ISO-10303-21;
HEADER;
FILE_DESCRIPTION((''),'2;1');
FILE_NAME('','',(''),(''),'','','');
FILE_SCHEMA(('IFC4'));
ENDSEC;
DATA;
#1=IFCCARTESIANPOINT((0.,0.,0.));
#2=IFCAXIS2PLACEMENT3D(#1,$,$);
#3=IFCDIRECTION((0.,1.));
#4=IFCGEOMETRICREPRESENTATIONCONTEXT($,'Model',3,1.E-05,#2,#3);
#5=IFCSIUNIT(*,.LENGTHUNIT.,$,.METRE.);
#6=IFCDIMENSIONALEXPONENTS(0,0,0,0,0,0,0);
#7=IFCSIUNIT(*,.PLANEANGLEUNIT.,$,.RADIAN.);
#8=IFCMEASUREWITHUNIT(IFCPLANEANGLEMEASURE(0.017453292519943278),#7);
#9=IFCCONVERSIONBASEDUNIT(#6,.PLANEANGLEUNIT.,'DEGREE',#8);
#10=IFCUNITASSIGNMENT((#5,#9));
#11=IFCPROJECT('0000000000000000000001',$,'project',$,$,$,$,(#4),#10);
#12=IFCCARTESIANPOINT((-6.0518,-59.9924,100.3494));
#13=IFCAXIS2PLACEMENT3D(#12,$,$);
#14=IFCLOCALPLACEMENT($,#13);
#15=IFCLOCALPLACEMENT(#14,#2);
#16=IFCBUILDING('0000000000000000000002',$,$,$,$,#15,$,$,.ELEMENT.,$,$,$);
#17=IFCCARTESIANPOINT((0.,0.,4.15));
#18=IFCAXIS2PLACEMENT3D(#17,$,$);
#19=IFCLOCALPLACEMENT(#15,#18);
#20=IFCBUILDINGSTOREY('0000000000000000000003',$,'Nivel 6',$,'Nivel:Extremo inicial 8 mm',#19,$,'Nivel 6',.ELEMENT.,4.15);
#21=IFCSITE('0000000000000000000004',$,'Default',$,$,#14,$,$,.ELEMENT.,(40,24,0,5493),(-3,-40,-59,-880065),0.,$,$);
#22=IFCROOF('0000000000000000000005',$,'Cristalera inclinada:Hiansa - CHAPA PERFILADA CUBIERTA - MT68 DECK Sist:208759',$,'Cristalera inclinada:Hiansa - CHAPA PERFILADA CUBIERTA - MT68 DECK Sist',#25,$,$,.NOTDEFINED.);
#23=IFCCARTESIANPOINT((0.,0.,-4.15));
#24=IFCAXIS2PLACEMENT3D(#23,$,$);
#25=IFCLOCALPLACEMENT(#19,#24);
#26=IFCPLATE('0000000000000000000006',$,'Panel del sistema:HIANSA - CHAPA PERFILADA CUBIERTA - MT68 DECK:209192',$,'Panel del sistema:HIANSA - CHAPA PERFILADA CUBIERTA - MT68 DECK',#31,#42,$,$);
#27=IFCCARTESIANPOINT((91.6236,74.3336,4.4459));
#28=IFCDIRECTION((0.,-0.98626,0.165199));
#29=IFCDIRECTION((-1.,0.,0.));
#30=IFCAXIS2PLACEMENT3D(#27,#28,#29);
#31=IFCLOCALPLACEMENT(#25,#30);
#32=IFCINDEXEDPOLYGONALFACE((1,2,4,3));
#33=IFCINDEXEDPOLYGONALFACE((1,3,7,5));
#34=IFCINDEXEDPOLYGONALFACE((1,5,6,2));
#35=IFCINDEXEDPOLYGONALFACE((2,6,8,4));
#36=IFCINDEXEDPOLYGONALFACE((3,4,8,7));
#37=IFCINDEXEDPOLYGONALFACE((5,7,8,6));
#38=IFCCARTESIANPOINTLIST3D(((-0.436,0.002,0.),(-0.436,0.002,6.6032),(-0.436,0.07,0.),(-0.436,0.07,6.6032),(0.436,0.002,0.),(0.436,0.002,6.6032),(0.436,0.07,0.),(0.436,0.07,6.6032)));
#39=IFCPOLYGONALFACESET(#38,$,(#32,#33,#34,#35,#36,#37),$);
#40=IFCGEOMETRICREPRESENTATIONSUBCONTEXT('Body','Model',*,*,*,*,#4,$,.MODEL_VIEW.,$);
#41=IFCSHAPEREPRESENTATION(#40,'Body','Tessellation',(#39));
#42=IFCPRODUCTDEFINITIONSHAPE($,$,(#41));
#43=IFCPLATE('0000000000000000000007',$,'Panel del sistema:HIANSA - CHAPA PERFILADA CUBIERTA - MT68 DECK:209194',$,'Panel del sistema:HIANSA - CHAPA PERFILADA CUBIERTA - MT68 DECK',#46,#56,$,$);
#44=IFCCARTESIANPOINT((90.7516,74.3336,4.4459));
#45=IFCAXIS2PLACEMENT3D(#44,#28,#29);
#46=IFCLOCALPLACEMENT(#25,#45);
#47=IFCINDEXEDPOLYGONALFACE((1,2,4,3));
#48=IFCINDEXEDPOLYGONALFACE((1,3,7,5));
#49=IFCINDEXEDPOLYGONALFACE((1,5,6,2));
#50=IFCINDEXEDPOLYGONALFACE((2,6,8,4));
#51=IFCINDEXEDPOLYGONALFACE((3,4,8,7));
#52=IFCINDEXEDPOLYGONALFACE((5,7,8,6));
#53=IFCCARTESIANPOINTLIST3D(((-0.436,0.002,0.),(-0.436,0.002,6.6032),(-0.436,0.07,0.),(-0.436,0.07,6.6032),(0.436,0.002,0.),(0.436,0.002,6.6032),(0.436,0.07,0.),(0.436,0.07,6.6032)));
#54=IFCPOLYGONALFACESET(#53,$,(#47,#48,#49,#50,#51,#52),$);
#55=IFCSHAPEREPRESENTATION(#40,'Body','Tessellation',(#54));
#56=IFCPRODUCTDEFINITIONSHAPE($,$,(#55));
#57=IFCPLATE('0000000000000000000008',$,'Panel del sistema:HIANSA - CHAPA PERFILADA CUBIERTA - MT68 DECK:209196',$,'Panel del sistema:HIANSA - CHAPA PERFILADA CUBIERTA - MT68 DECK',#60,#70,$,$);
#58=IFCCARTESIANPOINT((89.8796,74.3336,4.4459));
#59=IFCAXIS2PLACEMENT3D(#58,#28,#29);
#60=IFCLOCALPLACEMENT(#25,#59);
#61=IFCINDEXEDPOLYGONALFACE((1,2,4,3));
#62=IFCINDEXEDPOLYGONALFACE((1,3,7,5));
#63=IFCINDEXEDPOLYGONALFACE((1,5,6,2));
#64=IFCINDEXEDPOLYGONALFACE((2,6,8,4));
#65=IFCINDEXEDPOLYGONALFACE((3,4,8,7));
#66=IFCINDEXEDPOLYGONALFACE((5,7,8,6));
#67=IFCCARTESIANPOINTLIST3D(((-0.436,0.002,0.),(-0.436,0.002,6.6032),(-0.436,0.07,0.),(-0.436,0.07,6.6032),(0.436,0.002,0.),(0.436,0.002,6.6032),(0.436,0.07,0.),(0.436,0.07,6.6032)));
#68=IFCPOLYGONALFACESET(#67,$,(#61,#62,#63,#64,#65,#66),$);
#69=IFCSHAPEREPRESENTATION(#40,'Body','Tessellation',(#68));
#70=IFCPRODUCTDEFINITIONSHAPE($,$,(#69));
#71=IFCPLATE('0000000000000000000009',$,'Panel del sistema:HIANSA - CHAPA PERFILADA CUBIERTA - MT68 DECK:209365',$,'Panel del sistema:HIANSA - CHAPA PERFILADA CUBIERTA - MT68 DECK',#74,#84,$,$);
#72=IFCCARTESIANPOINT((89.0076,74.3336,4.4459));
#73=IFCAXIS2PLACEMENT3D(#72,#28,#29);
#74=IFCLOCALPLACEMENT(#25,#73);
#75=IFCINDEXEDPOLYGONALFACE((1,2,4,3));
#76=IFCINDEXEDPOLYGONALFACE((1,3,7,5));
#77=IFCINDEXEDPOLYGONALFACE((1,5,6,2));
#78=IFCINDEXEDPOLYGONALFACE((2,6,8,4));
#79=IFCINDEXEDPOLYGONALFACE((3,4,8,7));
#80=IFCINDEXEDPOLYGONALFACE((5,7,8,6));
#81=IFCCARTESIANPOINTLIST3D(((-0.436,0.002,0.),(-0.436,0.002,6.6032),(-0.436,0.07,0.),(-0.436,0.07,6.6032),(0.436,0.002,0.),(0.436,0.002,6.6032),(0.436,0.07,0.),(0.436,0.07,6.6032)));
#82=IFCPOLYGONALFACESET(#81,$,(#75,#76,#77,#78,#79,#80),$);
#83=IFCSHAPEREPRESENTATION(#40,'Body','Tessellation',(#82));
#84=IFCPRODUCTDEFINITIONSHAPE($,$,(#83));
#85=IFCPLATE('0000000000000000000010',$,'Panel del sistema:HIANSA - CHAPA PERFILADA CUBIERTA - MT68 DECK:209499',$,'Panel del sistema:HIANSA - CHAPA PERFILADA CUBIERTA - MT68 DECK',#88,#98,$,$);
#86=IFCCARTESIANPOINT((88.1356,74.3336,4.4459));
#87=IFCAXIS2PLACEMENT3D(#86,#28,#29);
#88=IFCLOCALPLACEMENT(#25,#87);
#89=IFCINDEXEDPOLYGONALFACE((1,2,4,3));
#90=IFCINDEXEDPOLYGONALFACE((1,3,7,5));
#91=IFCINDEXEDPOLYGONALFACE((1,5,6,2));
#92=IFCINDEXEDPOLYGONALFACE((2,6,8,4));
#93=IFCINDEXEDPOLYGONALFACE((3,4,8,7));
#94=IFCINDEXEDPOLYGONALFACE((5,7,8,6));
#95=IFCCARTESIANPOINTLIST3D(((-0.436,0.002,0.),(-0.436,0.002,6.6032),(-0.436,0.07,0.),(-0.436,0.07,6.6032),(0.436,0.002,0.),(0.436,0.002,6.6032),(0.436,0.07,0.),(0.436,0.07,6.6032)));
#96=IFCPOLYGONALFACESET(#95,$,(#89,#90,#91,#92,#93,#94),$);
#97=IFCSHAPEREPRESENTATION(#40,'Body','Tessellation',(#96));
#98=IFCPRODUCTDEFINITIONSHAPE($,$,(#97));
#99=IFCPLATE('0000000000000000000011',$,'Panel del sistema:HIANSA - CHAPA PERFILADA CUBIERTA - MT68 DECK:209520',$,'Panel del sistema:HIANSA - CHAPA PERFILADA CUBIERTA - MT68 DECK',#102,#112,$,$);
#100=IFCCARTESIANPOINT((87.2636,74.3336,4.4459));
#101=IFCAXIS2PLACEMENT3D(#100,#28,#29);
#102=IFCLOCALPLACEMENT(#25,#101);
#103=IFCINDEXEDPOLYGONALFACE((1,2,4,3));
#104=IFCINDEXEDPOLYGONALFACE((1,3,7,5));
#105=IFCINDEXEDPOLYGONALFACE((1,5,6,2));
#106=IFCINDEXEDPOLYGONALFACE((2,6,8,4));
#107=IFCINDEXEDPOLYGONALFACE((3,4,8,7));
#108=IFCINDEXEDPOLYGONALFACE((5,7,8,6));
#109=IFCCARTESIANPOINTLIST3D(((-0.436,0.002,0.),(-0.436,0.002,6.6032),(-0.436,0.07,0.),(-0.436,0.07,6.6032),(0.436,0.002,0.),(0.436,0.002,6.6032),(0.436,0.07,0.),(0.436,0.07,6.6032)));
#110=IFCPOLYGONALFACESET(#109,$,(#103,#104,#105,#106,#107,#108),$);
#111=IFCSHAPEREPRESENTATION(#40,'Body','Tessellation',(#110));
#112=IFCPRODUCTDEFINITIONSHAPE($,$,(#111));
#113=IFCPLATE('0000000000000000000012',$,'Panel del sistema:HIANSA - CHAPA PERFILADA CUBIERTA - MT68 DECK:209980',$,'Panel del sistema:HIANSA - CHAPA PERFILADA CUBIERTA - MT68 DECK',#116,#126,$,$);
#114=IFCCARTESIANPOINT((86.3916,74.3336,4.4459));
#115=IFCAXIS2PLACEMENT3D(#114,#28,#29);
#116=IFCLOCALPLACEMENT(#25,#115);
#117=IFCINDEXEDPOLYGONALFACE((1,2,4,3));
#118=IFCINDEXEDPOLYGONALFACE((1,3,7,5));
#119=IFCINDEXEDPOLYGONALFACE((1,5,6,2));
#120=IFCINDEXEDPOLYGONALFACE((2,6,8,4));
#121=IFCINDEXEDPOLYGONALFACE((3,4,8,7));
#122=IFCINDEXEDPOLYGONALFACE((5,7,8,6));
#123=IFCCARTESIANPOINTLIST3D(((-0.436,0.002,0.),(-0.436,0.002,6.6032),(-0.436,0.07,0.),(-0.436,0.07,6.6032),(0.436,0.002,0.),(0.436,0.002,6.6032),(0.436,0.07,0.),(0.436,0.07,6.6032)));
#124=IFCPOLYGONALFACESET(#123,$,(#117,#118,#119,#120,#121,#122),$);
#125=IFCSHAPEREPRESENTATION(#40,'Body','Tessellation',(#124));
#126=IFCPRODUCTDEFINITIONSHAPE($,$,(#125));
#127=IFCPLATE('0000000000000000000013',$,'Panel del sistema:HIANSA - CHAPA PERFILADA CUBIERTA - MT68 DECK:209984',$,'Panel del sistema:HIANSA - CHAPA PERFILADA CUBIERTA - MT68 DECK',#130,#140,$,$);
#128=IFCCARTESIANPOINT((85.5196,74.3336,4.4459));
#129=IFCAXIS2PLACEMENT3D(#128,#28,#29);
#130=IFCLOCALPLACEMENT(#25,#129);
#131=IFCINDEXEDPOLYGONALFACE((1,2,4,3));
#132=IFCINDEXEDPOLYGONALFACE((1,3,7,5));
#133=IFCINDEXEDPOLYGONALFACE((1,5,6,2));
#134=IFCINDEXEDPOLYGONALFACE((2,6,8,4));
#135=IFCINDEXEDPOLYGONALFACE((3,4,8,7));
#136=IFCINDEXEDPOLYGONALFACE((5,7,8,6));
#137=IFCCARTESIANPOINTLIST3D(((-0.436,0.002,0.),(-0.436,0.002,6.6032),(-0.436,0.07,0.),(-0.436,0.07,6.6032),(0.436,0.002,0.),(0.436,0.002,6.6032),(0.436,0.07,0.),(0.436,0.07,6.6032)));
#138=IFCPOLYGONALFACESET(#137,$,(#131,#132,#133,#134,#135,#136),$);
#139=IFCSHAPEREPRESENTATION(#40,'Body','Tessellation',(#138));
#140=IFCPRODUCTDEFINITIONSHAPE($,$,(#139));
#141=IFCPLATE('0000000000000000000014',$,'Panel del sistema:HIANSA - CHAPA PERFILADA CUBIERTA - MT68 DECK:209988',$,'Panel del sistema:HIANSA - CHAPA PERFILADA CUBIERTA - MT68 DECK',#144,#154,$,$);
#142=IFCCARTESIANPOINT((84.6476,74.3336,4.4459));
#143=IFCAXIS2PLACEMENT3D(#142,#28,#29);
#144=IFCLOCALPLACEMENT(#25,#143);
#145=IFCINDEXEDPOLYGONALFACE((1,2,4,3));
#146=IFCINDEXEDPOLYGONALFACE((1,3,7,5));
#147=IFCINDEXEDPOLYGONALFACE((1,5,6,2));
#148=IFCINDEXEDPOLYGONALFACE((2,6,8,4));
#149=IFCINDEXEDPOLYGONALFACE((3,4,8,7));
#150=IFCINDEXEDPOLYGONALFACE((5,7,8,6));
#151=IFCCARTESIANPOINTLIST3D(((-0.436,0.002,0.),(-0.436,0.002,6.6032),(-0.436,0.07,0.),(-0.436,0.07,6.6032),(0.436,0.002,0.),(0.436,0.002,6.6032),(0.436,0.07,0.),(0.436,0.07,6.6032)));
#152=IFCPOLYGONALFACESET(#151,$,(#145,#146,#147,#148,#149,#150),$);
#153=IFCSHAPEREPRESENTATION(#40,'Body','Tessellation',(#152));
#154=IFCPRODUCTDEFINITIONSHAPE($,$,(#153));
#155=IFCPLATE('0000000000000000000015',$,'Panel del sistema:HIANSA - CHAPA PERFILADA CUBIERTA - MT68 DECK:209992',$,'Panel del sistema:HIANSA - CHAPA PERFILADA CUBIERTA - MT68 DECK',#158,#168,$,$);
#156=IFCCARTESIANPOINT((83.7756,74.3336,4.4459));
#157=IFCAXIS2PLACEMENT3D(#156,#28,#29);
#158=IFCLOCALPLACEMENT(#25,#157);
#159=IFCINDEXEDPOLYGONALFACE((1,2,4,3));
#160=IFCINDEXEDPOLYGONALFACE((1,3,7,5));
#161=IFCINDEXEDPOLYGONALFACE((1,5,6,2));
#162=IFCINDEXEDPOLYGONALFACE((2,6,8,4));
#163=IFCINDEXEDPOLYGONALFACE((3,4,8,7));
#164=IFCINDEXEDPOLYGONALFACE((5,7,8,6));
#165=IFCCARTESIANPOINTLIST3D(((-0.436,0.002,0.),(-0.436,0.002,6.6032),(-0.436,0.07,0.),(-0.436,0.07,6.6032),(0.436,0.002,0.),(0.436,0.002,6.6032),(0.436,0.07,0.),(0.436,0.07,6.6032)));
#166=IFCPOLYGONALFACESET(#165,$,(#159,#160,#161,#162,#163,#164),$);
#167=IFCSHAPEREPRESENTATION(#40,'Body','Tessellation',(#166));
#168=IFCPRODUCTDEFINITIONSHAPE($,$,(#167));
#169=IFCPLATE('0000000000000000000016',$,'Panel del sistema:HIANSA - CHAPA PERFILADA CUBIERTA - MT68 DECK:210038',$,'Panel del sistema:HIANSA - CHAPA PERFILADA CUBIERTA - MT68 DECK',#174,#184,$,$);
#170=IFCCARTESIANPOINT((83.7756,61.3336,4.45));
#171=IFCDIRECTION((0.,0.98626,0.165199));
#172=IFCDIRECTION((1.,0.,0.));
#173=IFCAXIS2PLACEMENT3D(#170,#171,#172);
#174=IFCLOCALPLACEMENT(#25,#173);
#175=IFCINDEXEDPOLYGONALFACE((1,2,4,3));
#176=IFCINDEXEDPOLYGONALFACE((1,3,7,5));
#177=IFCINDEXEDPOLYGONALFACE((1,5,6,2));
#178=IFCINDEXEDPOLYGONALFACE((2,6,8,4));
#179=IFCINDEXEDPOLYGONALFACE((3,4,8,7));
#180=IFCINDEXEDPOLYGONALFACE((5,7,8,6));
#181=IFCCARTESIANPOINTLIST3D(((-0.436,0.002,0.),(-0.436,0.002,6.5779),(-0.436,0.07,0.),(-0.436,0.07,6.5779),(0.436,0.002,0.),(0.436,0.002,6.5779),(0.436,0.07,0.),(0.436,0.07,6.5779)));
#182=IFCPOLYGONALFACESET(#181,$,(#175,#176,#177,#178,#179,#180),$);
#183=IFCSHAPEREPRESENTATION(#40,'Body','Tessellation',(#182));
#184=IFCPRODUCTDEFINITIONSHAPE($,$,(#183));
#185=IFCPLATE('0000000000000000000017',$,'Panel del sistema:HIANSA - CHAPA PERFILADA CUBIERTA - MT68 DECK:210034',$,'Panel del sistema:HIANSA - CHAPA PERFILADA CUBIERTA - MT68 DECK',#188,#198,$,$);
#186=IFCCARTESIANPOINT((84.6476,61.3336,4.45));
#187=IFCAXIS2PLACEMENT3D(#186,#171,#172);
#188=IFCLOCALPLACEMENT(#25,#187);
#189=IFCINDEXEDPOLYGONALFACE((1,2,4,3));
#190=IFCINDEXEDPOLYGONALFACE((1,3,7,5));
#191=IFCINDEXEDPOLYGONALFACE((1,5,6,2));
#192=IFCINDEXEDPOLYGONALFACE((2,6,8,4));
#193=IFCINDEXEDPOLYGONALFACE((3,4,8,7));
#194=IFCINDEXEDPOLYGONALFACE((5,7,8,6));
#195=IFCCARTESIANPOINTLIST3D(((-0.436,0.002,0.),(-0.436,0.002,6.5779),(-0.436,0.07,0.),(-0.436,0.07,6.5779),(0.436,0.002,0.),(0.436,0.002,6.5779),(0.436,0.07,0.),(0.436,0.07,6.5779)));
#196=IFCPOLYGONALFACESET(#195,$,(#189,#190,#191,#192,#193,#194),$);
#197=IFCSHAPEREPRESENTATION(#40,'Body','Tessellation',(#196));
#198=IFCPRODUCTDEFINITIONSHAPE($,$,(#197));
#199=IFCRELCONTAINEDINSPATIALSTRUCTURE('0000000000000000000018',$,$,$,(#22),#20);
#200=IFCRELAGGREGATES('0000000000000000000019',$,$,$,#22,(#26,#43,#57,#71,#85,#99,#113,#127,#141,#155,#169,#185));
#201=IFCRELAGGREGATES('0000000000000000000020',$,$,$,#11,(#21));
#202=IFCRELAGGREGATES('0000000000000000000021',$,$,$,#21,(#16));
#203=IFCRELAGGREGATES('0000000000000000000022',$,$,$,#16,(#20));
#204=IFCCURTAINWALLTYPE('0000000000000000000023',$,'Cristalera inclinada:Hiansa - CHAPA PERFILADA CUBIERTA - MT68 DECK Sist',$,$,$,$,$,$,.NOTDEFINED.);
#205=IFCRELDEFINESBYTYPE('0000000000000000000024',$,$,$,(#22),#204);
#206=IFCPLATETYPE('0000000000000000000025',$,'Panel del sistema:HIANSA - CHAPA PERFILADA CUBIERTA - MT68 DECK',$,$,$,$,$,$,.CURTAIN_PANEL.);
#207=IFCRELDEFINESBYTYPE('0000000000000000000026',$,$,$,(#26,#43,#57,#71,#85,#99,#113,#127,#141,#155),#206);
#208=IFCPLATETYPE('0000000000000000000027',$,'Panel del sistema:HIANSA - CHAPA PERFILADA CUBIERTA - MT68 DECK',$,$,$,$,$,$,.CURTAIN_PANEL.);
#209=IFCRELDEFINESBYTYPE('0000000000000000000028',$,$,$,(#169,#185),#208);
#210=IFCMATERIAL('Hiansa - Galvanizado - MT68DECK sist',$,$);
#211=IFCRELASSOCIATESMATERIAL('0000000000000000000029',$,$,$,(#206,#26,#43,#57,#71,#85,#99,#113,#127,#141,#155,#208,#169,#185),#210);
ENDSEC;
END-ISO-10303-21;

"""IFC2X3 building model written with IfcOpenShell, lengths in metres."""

from ifc_helpers import new_model, entity, si_unit, converted_unit, direction, frame, origin, origin_2d_with_axis, place, context, subcontext, project, spatial, rectangle, extrude, source, transform, mapped, material, type_object, type_shapes, element, aggregate, save


model = new_model("IFC2X3")

# Units and contexts
model_context = context("Model", 3, precision=1e-05, world=origin(), true_north=direction((0.0, 1.0)))
body_context = subcontext(model_context, "Body", "Model", "MODEL_VIEW")
ifc_project = project(units=[si_unit("LENGTHUNIT", "METRE"), converted_unit("PLANEANGLEUNIT", "DEGREE", entity("IfcPlaneAngleMeasure", 0.017453292519943278), si_unit("PLANEANGLEUNIT", "RADIAN"), dimensions=[0, 0, 0, 0, 0, 0, 0])], contexts=[model_context])

# Site, building, storey
site_placement = place(None, frame((-6.0518, -59.9924, 100.3494)))
site = spatial("IfcSite", under=ifc_project, at=site_placement, Name="Default", CompositionType="ELEMENT", RefLatitude=(40, 24, 0, 5493), RefLongitude=(-3, -40, -59, -880065), RefElevation=0.0)
building_placement = place(site_placement, origin())
building = spatial("IfcBuilding", under=site, at=building_placement, CompositionType="ELEMENT")
storey_placement = place(building_placement, frame((0.0, 0.0, 4.15)))
storey = spatial("IfcBuildingStorey", under=building, at=storey_placement, Name="Nivel 6", ObjectType="Nivel:Extremo inicial 8 mm", LongName="Nivel 6", CompositionType="ELEMENT", Elevation=4.15)

# Roof, plates
curtain_wall_type = type_object("IfcCurtainWallType", Name="Cristalera inclinada:Hiansa - CHAPA PERFILADA CUBIERTA - MT68 DECK Sist", PredefinedType="NOTDEFINED")
roof_placement = place(storey_placement, frame((0.0, 0.0, -4.15)))
roof = element("IfcRoof", 1, at=roof_placement, inside=storey, type_object=curtain_wall_type, Name="Cristalera inclinada:Hiansa - CHAPA PERFILADA CUBIERTA - MT68 DECK Sist:208759", ObjectType="Cristalera inclinada:Hiansa - CHAPA PERFILADA CUBIERTA - MT68 DECK Sist", ShapeType="NOTDEFINED")
ifc_material_1 = material(Name="Hiansa - Galvanizado - MT68DECK sist")
plate_type_1 = type_object("IfcPlateType", Name="Panel del sistema:HIANSA - CHAPA PERFILADA CUBIERTA - MT68 DECK", PredefinedType="CURTAIN_PANEL", material=ifc_material_1)
shared_shape_1 = source(origin(), body_context, "Body", "SweptSolid", [
    extrude(rectangle(XDim=0.068, YDim=0.872, at=origin_2d_with_axis()), frame((0.0, 0.036, 0.0), z_axis=(0.0, 0.0, 1.0), x_axis=(0.0, 1.0, 0.0)), (0.0, 0.0, 1.0), 6.6032),
])
type_shapes(plate_type_1, [shared_shape_1])
plate_1_placement = place(roof_placement, frame((91.6236, 74.3336, 4.4459), z_axis=(0.0, -0.98626, 0.165199), x_axis=(-1.0, 0.0, 0.0)))
plate_1 = element("IfcPlate", 2, at=plate_1_placement, type_object=plate_type_1, material=ifc_material_1, Name="Panel del sistema:HIANSA - CHAPA PERFILADA CUBIERTA - MT68 DECK:209192", ObjectType="Panel del sistema:HIANSA - CHAPA PERFILADA CUBIERTA - MT68 DECK", context=body_context, shape_type="MappedRepresentation", body=[
    mapped(shared_shape_1, transform((0.0, 0.0, 0.0), scale=1.0)),
])
plate_2_placement = place(roof_placement, frame((90.7516, 74.3336, 4.4459), z_axis=(0.0, -0.98626, 0.165199), x_axis=(-1.0, 0.0, 0.0)))
plate_2 = element("IfcPlate", 3, at=plate_2_placement, type_object=plate_type_1, material=ifc_material_1, Name="Panel del sistema:HIANSA - CHAPA PERFILADA CUBIERTA - MT68 DECK:209194", ObjectType="Panel del sistema:HIANSA - CHAPA PERFILADA CUBIERTA - MT68 DECK", context=body_context, shape_type="MappedRepresentation", body=[
    mapped(shared_shape_1, transform((0.0, 0.0, 0.0), scale=1.0)),
])
plate_3_placement = place(roof_placement, frame((89.8796, 74.3336, 4.4459), z_axis=(0.0, -0.98626, 0.165199), x_axis=(-1.0, 0.0, 0.0)))
plate_3 = element("IfcPlate", 4, at=plate_3_placement, type_object=plate_type_1, material=ifc_material_1, Name="Panel del sistema:HIANSA - CHAPA PERFILADA CUBIERTA - MT68 DECK:209196", ObjectType="Panel del sistema:HIANSA - CHAPA PERFILADA CUBIERTA - MT68 DECK", context=body_context, shape_type="MappedRepresentation", body=[
    mapped(shared_shape_1, transform((0.0, 0.0, 0.0), scale=1.0)),
])
plate_4_placement = place(roof_placement, frame((89.0076, 74.3336, 4.4459), z_axis=(0.0, -0.98626, 0.165199), x_axis=(-1.0, 0.0, 0.0)))
plate_4 = element("IfcPlate", 5, at=plate_4_placement, type_object=plate_type_1, material=ifc_material_1, Name="Panel del sistema:HIANSA - CHAPA PERFILADA CUBIERTA - MT68 DECK:209365", ObjectType="Panel del sistema:HIANSA - CHAPA PERFILADA CUBIERTA - MT68 DECK", context=body_context, shape_type="MappedRepresentation", body=[
    mapped(shared_shape_1, transform((0.0, 0.0, 0.0), scale=1.0)),
])
plate_5_placement = place(roof_placement, frame((88.1356, 74.3336, 4.4459), z_axis=(0.0, -0.98626, 0.165199), x_axis=(-1.0, 0.0, 0.0)))
plate_5 = element("IfcPlate", 6, at=plate_5_placement, type_object=plate_type_1, material=ifc_material_1, Name="Panel del sistema:HIANSA - CHAPA PERFILADA CUBIERTA - MT68 DECK:209499", ObjectType="Panel del sistema:HIANSA - CHAPA PERFILADA CUBIERTA - MT68 DECK", context=body_context, shape_type="MappedRepresentation", body=[
    mapped(shared_shape_1, transform((0.0, 0.0, 0.0), scale=1.0)),
])
plate_6_placement = place(roof_placement, frame((87.2636, 74.3336, 4.4459), z_axis=(0.0, -0.98626, 0.165199), x_axis=(-1.0, 0.0, 0.0)))
plate_6 = element("IfcPlate", 7, at=plate_6_placement, type_object=plate_type_1, material=ifc_material_1, Name="Panel del sistema:HIANSA - CHAPA PERFILADA CUBIERTA - MT68 DECK:209520", ObjectType="Panel del sistema:HIANSA - CHAPA PERFILADA CUBIERTA - MT68 DECK", context=body_context, shape_type="MappedRepresentation", body=[
    mapped(shared_shape_1, transform((0.0, 0.0, 0.0), scale=1.0)),
])
plate_7_placement = place(roof_placement, frame((86.3916, 74.3336, 4.4459), z_axis=(0.0, -0.98626, 0.165199), x_axis=(-1.0, 0.0, 0.0)))
plate_7 = element("IfcPlate", 8, at=plate_7_placement, type_object=plate_type_1, material=ifc_material_1, Name="Panel del sistema:HIANSA - CHAPA PERFILADA CUBIERTA - MT68 DECK:209980", ObjectType="Panel del sistema:HIANSA - CHAPA PERFILADA CUBIERTA - MT68 DECK", context=body_context, shape_type="MappedRepresentation", body=[
    mapped(shared_shape_1, transform((0.0, 0.0, 0.0), scale=1.0)),
])
plate_8_placement = place(roof_placement, frame((85.5196, 74.3336, 4.4459), z_axis=(0.0, -0.98626, 0.165199), x_axis=(-1.0, 0.0, 0.0)))
plate_8 = element("IfcPlate", 9, at=plate_8_placement, type_object=plate_type_1, material=ifc_material_1, Name="Panel del sistema:HIANSA - CHAPA PERFILADA CUBIERTA - MT68 DECK:209984", ObjectType="Panel del sistema:HIANSA - CHAPA PERFILADA CUBIERTA - MT68 DECK", context=body_context, shape_type="MappedRepresentation", body=[
    mapped(shared_shape_1, transform((0.0, 0.0, 0.0), scale=1.0)),
])
plate_9_placement = place(roof_placement, frame((84.6476, 74.3336, 4.4459), z_axis=(0.0, -0.98626, 0.165199), x_axis=(-1.0, 0.0, 0.0)))
plate_9 = element("IfcPlate", 10, at=plate_9_placement, type_object=plate_type_1, material=ifc_material_1, Name="Panel del sistema:HIANSA - CHAPA PERFILADA CUBIERTA - MT68 DECK:209988", ObjectType="Panel del sistema:HIANSA - CHAPA PERFILADA CUBIERTA - MT68 DECK", context=body_context, shape_type="MappedRepresentation", body=[
    mapped(shared_shape_1, transform((0.0, 0.0, 0.0), scale=1.0)),
])
plate_10_placement = place(roof_placement, frame((83.7756, 74.3336, 4.4459), z_axis=(0.0, -0.98626, 0.165199), x_axis=(-1.0, 0.0, 0.0)))
plate_10 = element("IfcPlate", 11, at=plate_10_placement, type_object=plate_type_1, material=ifc_material_1, Name="Panel del sistema:HIANSA - CHAPA PERFILADA CUBIERTA - MT68 DECK:209992", ObjectType="Panel del sistema:HIANSA - CHAPA PERFILADA CUBIERTA - MT68 DECK", context=body_context, shape_type="MappedRepresentation", body=[
    mapped(shared_shape_1, transform((0.0, 0.0, 0.0), scale=1.0)),
])
plate_type_2 = type_object("IfcPlateType", Name="Panel del sistema:HIANSA - CHAPA PERFILADA CUBIERTA - MT68 DECK", PredefinedType="CURTAIN_PANEL", material=ifc_material_1)
shared_shape_2 = source(origin(), body_context, "Body", "SweptSolid", [
    extrude(rectangle(XDim=0.068, YDim=0.872, at=origin_2d_with_axis()), frame((0.0, 0.036, 0.0), z_axis=(0.0, 0.0, 1.0), x_axis=(0.0, 1.0, 0.0)), (0.0, 0.0, 1.0), 6.5779),
])
type_shapes(plate_type_2, [shared_shape_2])
plate_11_placement = place(roof_placement, frame((83.7756, 61.3336, 4.45), z_axis=(0.0, 0.98626, 0.165199), x_axis=(1.0, 0.0, 0.0)))
plate_11 = element("IfcPlate", 12, at=plate_11_placement, type_object=plate_type_2, material=ifc_material_1, Name="Panel del sistema:HIANSA - CHAPA PERFILADA CUBIERTA - MT68 DECK:210038", ObjectType="Panel del sistema:HIANSA - CHAPA PERFILADA CUBIERTA - MT68 DECK", context=body_context, shape_type="MappedRepresentation", body=[
    mapped(shared_shape_2, transform((0.0, 0.0, 0.0), scale=1.0)),
])
plate_12_placement = place(roof_placement, frame((84.6476, 61.3336, 4.45), z_axis=(0.0, 0.98626, 0.165199), x_axis=(1.0, 0.0, 0.0)))
plate_12 = element("IfcPlate", 13, at=plate_12_placement, type_object=plate_type_2, material=ifc_material_1, Name="Panel del sistema:HIANSA - CHAPA PERFILADA CUBIERTA - MT68 DECK:210034", ObjectType="Panel del sistema:HIANSA - CHAPA PERFILADA CUBIERTA - MT68 DECK", context=body_context, shape_type="MappedRepresentation", body=[
    mapped(shared_shape_2, transform((0.0, 0.0, 0.0), scale=1.0)),
])
aggregate(roof, [plate_1, plate_2, plate_3, plate_4, plate_5, plate_6, plate_7, plate_8, plate_9, plate_10, plate_11, plate_12])

save(model, "model.ifc")
